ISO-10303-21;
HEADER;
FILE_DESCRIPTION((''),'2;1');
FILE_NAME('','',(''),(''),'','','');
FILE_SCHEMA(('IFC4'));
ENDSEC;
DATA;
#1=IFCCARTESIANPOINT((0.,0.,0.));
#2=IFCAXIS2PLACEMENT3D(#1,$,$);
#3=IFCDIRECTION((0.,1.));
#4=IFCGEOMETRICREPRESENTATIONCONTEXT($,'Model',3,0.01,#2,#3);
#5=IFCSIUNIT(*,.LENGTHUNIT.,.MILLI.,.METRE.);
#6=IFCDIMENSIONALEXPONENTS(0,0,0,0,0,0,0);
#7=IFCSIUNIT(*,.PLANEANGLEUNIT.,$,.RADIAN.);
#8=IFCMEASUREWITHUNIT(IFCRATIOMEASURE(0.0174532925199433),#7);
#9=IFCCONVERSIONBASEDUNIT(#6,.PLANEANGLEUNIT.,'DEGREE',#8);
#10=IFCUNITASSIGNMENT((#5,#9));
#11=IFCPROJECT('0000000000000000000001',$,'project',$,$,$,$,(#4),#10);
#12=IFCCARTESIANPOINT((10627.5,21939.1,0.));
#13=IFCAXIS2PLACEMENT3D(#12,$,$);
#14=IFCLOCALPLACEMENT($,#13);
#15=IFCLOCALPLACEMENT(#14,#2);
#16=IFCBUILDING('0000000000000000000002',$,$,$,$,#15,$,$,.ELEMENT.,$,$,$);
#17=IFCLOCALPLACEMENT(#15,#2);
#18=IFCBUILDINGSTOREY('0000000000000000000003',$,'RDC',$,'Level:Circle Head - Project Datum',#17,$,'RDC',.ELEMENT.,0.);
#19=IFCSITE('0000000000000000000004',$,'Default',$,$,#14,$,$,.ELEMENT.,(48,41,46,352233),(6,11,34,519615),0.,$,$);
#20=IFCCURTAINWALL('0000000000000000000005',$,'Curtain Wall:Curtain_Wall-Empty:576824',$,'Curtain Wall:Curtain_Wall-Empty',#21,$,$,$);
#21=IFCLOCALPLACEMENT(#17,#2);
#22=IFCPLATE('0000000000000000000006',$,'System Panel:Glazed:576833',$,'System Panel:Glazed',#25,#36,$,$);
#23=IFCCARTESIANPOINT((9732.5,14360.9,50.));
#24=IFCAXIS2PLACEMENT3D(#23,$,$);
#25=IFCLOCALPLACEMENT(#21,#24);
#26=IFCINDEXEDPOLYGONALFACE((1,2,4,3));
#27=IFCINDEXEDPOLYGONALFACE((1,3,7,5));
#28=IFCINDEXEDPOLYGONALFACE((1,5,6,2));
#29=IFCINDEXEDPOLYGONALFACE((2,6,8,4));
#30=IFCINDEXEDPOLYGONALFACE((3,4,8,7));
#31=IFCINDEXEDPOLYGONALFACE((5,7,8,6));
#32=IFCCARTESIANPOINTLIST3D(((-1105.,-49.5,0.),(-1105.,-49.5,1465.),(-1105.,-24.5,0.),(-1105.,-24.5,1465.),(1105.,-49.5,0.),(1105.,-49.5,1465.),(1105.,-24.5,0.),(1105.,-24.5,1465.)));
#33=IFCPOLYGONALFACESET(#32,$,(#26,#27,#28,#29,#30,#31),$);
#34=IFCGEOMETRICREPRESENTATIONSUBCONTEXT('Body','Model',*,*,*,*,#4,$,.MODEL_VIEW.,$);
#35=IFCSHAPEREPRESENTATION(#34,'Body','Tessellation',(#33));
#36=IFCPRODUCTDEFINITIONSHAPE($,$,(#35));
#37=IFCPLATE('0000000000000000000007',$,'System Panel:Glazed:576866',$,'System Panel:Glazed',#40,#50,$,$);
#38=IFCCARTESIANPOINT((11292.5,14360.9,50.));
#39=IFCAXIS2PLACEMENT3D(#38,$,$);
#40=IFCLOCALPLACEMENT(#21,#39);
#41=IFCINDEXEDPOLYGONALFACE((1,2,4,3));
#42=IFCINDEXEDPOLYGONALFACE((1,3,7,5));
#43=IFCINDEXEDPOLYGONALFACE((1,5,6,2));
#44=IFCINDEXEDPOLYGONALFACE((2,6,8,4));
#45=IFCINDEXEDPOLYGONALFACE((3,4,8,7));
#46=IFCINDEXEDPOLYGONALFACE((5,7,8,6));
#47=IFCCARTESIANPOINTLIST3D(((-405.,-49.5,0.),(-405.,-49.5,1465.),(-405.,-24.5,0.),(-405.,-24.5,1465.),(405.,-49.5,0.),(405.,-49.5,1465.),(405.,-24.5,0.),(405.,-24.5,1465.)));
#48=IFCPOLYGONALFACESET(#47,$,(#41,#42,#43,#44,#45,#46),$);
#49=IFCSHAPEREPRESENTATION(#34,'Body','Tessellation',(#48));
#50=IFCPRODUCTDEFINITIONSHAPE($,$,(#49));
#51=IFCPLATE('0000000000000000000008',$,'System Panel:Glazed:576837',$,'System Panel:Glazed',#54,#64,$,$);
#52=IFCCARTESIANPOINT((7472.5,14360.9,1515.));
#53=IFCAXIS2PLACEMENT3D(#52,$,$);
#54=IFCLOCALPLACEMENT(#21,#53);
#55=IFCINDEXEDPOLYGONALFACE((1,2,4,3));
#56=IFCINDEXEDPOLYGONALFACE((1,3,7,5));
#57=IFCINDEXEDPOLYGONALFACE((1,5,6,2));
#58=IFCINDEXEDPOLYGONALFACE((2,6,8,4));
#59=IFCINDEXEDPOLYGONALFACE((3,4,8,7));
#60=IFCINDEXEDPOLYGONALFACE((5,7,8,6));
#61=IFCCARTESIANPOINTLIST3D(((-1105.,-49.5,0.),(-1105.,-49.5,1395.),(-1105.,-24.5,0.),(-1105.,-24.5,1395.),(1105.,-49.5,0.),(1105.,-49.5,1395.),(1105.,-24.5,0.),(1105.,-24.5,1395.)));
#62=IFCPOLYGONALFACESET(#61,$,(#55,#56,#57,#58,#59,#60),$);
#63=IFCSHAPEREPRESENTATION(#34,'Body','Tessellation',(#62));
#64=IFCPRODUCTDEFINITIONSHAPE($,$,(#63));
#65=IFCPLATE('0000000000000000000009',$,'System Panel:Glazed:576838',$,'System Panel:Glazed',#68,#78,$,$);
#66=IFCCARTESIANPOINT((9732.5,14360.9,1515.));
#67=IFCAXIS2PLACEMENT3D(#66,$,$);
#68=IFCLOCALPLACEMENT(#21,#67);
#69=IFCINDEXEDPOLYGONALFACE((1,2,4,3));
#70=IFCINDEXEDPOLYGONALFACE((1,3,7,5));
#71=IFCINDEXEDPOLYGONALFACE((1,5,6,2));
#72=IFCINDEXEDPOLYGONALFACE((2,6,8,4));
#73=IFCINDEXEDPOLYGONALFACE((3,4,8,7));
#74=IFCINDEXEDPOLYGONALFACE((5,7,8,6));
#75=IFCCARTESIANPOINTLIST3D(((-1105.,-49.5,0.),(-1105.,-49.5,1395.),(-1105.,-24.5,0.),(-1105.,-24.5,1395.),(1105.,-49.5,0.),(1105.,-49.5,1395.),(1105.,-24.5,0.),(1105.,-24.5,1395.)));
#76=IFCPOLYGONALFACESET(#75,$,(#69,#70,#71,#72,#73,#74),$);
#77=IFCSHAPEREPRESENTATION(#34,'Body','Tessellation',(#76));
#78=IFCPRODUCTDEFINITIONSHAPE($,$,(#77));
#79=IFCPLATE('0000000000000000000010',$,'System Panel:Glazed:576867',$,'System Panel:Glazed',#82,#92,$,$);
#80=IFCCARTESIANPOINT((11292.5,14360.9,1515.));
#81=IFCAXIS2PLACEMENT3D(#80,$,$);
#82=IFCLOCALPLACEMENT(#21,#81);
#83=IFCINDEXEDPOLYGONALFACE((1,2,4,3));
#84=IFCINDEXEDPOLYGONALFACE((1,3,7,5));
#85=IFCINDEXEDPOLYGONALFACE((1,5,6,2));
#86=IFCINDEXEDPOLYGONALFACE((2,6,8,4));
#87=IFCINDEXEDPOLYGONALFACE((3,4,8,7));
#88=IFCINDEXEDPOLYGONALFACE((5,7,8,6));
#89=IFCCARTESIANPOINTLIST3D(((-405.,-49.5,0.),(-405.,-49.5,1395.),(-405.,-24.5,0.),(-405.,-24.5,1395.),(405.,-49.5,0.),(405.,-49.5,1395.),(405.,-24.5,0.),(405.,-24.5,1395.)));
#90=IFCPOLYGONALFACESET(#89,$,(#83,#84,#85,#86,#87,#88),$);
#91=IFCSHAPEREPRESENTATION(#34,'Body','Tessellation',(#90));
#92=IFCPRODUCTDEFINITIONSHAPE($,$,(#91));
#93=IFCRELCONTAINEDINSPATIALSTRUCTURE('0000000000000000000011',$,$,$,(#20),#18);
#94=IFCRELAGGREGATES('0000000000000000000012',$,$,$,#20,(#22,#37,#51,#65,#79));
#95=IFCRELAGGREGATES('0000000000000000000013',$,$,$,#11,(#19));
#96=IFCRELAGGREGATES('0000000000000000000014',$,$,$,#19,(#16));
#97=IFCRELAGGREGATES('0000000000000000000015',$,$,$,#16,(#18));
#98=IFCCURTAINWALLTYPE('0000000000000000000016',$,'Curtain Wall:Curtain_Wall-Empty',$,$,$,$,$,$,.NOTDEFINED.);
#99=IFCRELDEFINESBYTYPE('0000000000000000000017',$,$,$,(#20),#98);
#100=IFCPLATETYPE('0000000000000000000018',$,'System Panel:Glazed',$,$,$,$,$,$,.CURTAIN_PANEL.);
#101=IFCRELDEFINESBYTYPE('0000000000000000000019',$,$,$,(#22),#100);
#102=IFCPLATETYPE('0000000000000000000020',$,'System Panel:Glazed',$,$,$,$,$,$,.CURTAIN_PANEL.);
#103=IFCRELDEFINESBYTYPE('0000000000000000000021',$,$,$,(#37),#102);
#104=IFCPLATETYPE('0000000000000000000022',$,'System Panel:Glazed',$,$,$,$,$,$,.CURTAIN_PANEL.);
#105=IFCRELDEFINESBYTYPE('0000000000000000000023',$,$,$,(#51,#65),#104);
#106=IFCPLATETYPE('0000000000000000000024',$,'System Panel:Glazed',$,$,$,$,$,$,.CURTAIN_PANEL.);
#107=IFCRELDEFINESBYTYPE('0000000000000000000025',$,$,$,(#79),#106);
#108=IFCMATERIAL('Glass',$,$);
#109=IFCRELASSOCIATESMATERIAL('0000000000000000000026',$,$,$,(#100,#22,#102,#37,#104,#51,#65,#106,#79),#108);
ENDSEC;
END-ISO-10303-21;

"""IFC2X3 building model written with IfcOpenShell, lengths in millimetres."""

from ifc_helpers import new_model, entity, si_unit, converted_unit, direction, frame, frame_2d, origin, place, context, subcontext, project, spatial, rectangle, extrude, source, transform, mapped, material, type_object, type_shapes, element, aggregate, save


model = new_model("IFC2X3")

# Units and contexts
model_context = context("Model", 3, precision=0.01, world=origin(), true_north=direction((0.0, 1.0)))
body_context = subcontext(model_context, "Body", "Model", "MODEL_VIEW")
ifc_project = project(units=[si_unit("LENGTHUNIT", "METRE", prefix="MILLI"), converted_unit("PLANEANGLEUNIT", "DEGREE", entity("IfcRatioMeasure", 0.0174532925199433), si_unit("PLANEANGLEUNIT", "RADIAN"), dimensions=[0, 0, 0, 0, 0, 0, 0])], contexts=[model_context])

# Site, building, storey
site_placement = place(None, frame((10627.5, 21939.1, 0.0)))
site = spatial("IfcSite", under=ifc_project, at=site_placement, Name="Default", CompositionType="ELEMENT", RefLatitude=(48, 41, 46, 352233), RefLongitude=(6, 11, 34, 519615), RefElevation=0.0)
building_placement = place(site_placement, origin())
building = spatial("IfcBuilding", under=site, at=building_placement, CompositionType="ELEMENT")
storey_placement = place(building_placement, origin())
storey = spatial("IfcBuildingStorey", under=building, at=storey_placement, Name="RDC", ObjectType="Level:Circle Head - Project Datum", LongName="RDC", CompositionType="ELEMENT", Elevation=0.0)

# Curtain wall
curtain_wall_type = type_object("IfcCurtainWallType", Name="Curtain Wall:Curtain_Wall-Empty", PredefinedType="NOTDEFINED")
curtain_wall_1_placement = place(storey_placement, origin())
curtain_wall_1 = element("IfcCurtainWall", 1, at=curtain_wall_1_placement, inside=storey, type_object=curtain_wall_type, Name="Curtain Wall:Curtain_Wall-Empty:576824", ObjectType="Curtain Wall:Curtain_Wall-Empty")

# Plates
ifc_material_1 = material(Name="Glass")
plate_type_1 = type_object("IfcPlateType", Name="System Panel:Glazed", PredefinedType="CURTAIN_PANEL", material=ifc_material_1)
shared_shape_1 = source(origin(), body_context, "Body", "SweptSolid", [
    extrude(rectangle(XDim=25.0, YDim=2210.0, at=frame_2d((0.0, 0.0), x_axis=(1.0, 0.0))), frame((0.0, -37.0, 0.0), z_axis=(0.0, 0.0, 1.0), x_axis=(0.0, 1.0, 0.0)), (0.0, 0.0, 1.0), 1465.0),
])
type_shapes(plate_type_1, [shared_shape_1])
plate_1_placement = place(curtain_wall_1_placement, frame((9732.5, 14360.9, 50.0)))
plate_1 = element("IfcPlate", 2, at=plate_1_placement, type_object=plate_type_1, material=ifc_material_1, Name="System Panel:Glazed:576833", ObjectType="System Panel:Glazed", context=body_context, shape_type="MappedRepresentation", body=[
    mapped(shared_shape_1, transform((0.0, 0.0, 0.0), scale=1.0)),
])
plate_type_2 = type_object("IfcPlateType", Name="System Panel:Glazed", PredefinedType="CURTAIN_PANEL", material=ifc_material_1)
shared_shape_2 = source(origin(), body_context, "Body", "SweptSolid", [
    extrude(rectangle(XDim=25.0, YDim=810.0, at=frame_2d((0.0, 0.0), x_axis=(1.0, 0.0))), frame((0.0, -37.0, 0.0), z_axis=(0.0, 0.0, 1.0), x_axis=(0.0, 1.0, 0.0)), (0.0, 0.0, 1.0), 1465.0),
])
type_shapes(plate_type_2, [shared_shape_2])
plate_2_placement = place(curtain_wall_1_placement, frame((11292.5, 14360.9, 50.0)))
plate_2 = element("IfcPlate", 3, at=plate_2_placement, type_object=plate_type_2, material=ifc_material_1, Name="System Panel:Glazed:576866", ObjectType="System Panel:Glazed", context=body_context, shape_type="MappedRepresentation", body=[
    mapped(shared_shape_2, transform((0.0, 0.0, 0.0), scale=1.0)),
])
plate_type_3 = type_object("IfcPlateType", Name="System Panel:Glazed", PredefinedType="CURTAIN_PANEL", material=ifc_material_1)
shared_shape_3 = source(origin(), body_context, "Body", "SweptSolid", [
    extrude(rectangle(XDim=25.0, YDim=2210.0, at=frame_2d((0.0, 0.0), x_axis=(1.0, 0.0))), frame((0.0, -37.0, 0.0), z_axis=(0.0, 0.0, 1.0), x_axis=(0.0, 1.0, 0.0)), (0.0, 0.0, 1.0), 1395.0),
])
type_shapes(plate_type_3, [shared_shape_3])
plate_3_placement = place(curtain_wall_1_placement, frame((7472.5, 14360.9, 1515.0)))
plate_3 = element("IfcPlate", 4, at=plate_3_placement, type_object=plate_type_3, material=ifc_material_1, Name="System Panel:Glazed:576837", ObjectType="System Panel:Glazed", context=body_context, shape_type="MappedRepresentation", body=[
    mapped(shared_shape_3, transform((0.0, 0.0, 0.0), scale=1.0)),
])
plate_4_placement = place(curtain_wall_1_placement, frame((9732.5, 14360.9, 1515.0)))
plate_4 = element("IfcPlate", 5, at=plate_4_placement, type_object=plate_type_3, material=ifc_material_1, Name="System Panel:Glazed:576838", ObjectType="System Panel:Glazed", context=body_context, shape_type="MappedRepresentation", body=[
    mapped(shared_shape_3, transform((0.0, 0.0, 0.0), scale=1.0)),
])
plate_type_4 = type_object("IfcPlateType", Name="System Panel:Glazed", PredefinedType="CURTAIN_PANEL", material=ifc_material_1)
shared_shape_4 = source(origin(), body_context, "Body", "SweptSolid", [
    extrude(rectangle(XDim=25.0, YDim=810.0, at=frame_2d((0.0, 0.0), x_axis=(1.0, 0.0))), frame((0.0, -37.0, 0.0), z_axis=(0.0, 0.0, 1.0), x_axis=(0.0, 1.0, 0.0)), (0.0, 0.0, 1.0), 1395.0),
])
type_shapes(plate_type_4, [shared_shape_4])
plate_5_placement = place(curtain_wall_1_placement, frame((11292.5, 14360.9, 1515.0)))
plate_5 = element("IfcPlate", 6, at=plate_5_placement, type_object=plate_type_4, material=ifc_material_1, Name="System Panel:Glazed:576867", ObjectType="System Panel:Glazed", context=body_context, shape_type="MappedRepresentation", body=[
    mapped(shared_shape_4, transform((0.0, 0.0, 0.0), scale=1.0)),
])
aggregate(curtain_wall_1, [plate_1, plate_2, plate_3, plate_4, plate_5])

save(model, "model.ifc")
